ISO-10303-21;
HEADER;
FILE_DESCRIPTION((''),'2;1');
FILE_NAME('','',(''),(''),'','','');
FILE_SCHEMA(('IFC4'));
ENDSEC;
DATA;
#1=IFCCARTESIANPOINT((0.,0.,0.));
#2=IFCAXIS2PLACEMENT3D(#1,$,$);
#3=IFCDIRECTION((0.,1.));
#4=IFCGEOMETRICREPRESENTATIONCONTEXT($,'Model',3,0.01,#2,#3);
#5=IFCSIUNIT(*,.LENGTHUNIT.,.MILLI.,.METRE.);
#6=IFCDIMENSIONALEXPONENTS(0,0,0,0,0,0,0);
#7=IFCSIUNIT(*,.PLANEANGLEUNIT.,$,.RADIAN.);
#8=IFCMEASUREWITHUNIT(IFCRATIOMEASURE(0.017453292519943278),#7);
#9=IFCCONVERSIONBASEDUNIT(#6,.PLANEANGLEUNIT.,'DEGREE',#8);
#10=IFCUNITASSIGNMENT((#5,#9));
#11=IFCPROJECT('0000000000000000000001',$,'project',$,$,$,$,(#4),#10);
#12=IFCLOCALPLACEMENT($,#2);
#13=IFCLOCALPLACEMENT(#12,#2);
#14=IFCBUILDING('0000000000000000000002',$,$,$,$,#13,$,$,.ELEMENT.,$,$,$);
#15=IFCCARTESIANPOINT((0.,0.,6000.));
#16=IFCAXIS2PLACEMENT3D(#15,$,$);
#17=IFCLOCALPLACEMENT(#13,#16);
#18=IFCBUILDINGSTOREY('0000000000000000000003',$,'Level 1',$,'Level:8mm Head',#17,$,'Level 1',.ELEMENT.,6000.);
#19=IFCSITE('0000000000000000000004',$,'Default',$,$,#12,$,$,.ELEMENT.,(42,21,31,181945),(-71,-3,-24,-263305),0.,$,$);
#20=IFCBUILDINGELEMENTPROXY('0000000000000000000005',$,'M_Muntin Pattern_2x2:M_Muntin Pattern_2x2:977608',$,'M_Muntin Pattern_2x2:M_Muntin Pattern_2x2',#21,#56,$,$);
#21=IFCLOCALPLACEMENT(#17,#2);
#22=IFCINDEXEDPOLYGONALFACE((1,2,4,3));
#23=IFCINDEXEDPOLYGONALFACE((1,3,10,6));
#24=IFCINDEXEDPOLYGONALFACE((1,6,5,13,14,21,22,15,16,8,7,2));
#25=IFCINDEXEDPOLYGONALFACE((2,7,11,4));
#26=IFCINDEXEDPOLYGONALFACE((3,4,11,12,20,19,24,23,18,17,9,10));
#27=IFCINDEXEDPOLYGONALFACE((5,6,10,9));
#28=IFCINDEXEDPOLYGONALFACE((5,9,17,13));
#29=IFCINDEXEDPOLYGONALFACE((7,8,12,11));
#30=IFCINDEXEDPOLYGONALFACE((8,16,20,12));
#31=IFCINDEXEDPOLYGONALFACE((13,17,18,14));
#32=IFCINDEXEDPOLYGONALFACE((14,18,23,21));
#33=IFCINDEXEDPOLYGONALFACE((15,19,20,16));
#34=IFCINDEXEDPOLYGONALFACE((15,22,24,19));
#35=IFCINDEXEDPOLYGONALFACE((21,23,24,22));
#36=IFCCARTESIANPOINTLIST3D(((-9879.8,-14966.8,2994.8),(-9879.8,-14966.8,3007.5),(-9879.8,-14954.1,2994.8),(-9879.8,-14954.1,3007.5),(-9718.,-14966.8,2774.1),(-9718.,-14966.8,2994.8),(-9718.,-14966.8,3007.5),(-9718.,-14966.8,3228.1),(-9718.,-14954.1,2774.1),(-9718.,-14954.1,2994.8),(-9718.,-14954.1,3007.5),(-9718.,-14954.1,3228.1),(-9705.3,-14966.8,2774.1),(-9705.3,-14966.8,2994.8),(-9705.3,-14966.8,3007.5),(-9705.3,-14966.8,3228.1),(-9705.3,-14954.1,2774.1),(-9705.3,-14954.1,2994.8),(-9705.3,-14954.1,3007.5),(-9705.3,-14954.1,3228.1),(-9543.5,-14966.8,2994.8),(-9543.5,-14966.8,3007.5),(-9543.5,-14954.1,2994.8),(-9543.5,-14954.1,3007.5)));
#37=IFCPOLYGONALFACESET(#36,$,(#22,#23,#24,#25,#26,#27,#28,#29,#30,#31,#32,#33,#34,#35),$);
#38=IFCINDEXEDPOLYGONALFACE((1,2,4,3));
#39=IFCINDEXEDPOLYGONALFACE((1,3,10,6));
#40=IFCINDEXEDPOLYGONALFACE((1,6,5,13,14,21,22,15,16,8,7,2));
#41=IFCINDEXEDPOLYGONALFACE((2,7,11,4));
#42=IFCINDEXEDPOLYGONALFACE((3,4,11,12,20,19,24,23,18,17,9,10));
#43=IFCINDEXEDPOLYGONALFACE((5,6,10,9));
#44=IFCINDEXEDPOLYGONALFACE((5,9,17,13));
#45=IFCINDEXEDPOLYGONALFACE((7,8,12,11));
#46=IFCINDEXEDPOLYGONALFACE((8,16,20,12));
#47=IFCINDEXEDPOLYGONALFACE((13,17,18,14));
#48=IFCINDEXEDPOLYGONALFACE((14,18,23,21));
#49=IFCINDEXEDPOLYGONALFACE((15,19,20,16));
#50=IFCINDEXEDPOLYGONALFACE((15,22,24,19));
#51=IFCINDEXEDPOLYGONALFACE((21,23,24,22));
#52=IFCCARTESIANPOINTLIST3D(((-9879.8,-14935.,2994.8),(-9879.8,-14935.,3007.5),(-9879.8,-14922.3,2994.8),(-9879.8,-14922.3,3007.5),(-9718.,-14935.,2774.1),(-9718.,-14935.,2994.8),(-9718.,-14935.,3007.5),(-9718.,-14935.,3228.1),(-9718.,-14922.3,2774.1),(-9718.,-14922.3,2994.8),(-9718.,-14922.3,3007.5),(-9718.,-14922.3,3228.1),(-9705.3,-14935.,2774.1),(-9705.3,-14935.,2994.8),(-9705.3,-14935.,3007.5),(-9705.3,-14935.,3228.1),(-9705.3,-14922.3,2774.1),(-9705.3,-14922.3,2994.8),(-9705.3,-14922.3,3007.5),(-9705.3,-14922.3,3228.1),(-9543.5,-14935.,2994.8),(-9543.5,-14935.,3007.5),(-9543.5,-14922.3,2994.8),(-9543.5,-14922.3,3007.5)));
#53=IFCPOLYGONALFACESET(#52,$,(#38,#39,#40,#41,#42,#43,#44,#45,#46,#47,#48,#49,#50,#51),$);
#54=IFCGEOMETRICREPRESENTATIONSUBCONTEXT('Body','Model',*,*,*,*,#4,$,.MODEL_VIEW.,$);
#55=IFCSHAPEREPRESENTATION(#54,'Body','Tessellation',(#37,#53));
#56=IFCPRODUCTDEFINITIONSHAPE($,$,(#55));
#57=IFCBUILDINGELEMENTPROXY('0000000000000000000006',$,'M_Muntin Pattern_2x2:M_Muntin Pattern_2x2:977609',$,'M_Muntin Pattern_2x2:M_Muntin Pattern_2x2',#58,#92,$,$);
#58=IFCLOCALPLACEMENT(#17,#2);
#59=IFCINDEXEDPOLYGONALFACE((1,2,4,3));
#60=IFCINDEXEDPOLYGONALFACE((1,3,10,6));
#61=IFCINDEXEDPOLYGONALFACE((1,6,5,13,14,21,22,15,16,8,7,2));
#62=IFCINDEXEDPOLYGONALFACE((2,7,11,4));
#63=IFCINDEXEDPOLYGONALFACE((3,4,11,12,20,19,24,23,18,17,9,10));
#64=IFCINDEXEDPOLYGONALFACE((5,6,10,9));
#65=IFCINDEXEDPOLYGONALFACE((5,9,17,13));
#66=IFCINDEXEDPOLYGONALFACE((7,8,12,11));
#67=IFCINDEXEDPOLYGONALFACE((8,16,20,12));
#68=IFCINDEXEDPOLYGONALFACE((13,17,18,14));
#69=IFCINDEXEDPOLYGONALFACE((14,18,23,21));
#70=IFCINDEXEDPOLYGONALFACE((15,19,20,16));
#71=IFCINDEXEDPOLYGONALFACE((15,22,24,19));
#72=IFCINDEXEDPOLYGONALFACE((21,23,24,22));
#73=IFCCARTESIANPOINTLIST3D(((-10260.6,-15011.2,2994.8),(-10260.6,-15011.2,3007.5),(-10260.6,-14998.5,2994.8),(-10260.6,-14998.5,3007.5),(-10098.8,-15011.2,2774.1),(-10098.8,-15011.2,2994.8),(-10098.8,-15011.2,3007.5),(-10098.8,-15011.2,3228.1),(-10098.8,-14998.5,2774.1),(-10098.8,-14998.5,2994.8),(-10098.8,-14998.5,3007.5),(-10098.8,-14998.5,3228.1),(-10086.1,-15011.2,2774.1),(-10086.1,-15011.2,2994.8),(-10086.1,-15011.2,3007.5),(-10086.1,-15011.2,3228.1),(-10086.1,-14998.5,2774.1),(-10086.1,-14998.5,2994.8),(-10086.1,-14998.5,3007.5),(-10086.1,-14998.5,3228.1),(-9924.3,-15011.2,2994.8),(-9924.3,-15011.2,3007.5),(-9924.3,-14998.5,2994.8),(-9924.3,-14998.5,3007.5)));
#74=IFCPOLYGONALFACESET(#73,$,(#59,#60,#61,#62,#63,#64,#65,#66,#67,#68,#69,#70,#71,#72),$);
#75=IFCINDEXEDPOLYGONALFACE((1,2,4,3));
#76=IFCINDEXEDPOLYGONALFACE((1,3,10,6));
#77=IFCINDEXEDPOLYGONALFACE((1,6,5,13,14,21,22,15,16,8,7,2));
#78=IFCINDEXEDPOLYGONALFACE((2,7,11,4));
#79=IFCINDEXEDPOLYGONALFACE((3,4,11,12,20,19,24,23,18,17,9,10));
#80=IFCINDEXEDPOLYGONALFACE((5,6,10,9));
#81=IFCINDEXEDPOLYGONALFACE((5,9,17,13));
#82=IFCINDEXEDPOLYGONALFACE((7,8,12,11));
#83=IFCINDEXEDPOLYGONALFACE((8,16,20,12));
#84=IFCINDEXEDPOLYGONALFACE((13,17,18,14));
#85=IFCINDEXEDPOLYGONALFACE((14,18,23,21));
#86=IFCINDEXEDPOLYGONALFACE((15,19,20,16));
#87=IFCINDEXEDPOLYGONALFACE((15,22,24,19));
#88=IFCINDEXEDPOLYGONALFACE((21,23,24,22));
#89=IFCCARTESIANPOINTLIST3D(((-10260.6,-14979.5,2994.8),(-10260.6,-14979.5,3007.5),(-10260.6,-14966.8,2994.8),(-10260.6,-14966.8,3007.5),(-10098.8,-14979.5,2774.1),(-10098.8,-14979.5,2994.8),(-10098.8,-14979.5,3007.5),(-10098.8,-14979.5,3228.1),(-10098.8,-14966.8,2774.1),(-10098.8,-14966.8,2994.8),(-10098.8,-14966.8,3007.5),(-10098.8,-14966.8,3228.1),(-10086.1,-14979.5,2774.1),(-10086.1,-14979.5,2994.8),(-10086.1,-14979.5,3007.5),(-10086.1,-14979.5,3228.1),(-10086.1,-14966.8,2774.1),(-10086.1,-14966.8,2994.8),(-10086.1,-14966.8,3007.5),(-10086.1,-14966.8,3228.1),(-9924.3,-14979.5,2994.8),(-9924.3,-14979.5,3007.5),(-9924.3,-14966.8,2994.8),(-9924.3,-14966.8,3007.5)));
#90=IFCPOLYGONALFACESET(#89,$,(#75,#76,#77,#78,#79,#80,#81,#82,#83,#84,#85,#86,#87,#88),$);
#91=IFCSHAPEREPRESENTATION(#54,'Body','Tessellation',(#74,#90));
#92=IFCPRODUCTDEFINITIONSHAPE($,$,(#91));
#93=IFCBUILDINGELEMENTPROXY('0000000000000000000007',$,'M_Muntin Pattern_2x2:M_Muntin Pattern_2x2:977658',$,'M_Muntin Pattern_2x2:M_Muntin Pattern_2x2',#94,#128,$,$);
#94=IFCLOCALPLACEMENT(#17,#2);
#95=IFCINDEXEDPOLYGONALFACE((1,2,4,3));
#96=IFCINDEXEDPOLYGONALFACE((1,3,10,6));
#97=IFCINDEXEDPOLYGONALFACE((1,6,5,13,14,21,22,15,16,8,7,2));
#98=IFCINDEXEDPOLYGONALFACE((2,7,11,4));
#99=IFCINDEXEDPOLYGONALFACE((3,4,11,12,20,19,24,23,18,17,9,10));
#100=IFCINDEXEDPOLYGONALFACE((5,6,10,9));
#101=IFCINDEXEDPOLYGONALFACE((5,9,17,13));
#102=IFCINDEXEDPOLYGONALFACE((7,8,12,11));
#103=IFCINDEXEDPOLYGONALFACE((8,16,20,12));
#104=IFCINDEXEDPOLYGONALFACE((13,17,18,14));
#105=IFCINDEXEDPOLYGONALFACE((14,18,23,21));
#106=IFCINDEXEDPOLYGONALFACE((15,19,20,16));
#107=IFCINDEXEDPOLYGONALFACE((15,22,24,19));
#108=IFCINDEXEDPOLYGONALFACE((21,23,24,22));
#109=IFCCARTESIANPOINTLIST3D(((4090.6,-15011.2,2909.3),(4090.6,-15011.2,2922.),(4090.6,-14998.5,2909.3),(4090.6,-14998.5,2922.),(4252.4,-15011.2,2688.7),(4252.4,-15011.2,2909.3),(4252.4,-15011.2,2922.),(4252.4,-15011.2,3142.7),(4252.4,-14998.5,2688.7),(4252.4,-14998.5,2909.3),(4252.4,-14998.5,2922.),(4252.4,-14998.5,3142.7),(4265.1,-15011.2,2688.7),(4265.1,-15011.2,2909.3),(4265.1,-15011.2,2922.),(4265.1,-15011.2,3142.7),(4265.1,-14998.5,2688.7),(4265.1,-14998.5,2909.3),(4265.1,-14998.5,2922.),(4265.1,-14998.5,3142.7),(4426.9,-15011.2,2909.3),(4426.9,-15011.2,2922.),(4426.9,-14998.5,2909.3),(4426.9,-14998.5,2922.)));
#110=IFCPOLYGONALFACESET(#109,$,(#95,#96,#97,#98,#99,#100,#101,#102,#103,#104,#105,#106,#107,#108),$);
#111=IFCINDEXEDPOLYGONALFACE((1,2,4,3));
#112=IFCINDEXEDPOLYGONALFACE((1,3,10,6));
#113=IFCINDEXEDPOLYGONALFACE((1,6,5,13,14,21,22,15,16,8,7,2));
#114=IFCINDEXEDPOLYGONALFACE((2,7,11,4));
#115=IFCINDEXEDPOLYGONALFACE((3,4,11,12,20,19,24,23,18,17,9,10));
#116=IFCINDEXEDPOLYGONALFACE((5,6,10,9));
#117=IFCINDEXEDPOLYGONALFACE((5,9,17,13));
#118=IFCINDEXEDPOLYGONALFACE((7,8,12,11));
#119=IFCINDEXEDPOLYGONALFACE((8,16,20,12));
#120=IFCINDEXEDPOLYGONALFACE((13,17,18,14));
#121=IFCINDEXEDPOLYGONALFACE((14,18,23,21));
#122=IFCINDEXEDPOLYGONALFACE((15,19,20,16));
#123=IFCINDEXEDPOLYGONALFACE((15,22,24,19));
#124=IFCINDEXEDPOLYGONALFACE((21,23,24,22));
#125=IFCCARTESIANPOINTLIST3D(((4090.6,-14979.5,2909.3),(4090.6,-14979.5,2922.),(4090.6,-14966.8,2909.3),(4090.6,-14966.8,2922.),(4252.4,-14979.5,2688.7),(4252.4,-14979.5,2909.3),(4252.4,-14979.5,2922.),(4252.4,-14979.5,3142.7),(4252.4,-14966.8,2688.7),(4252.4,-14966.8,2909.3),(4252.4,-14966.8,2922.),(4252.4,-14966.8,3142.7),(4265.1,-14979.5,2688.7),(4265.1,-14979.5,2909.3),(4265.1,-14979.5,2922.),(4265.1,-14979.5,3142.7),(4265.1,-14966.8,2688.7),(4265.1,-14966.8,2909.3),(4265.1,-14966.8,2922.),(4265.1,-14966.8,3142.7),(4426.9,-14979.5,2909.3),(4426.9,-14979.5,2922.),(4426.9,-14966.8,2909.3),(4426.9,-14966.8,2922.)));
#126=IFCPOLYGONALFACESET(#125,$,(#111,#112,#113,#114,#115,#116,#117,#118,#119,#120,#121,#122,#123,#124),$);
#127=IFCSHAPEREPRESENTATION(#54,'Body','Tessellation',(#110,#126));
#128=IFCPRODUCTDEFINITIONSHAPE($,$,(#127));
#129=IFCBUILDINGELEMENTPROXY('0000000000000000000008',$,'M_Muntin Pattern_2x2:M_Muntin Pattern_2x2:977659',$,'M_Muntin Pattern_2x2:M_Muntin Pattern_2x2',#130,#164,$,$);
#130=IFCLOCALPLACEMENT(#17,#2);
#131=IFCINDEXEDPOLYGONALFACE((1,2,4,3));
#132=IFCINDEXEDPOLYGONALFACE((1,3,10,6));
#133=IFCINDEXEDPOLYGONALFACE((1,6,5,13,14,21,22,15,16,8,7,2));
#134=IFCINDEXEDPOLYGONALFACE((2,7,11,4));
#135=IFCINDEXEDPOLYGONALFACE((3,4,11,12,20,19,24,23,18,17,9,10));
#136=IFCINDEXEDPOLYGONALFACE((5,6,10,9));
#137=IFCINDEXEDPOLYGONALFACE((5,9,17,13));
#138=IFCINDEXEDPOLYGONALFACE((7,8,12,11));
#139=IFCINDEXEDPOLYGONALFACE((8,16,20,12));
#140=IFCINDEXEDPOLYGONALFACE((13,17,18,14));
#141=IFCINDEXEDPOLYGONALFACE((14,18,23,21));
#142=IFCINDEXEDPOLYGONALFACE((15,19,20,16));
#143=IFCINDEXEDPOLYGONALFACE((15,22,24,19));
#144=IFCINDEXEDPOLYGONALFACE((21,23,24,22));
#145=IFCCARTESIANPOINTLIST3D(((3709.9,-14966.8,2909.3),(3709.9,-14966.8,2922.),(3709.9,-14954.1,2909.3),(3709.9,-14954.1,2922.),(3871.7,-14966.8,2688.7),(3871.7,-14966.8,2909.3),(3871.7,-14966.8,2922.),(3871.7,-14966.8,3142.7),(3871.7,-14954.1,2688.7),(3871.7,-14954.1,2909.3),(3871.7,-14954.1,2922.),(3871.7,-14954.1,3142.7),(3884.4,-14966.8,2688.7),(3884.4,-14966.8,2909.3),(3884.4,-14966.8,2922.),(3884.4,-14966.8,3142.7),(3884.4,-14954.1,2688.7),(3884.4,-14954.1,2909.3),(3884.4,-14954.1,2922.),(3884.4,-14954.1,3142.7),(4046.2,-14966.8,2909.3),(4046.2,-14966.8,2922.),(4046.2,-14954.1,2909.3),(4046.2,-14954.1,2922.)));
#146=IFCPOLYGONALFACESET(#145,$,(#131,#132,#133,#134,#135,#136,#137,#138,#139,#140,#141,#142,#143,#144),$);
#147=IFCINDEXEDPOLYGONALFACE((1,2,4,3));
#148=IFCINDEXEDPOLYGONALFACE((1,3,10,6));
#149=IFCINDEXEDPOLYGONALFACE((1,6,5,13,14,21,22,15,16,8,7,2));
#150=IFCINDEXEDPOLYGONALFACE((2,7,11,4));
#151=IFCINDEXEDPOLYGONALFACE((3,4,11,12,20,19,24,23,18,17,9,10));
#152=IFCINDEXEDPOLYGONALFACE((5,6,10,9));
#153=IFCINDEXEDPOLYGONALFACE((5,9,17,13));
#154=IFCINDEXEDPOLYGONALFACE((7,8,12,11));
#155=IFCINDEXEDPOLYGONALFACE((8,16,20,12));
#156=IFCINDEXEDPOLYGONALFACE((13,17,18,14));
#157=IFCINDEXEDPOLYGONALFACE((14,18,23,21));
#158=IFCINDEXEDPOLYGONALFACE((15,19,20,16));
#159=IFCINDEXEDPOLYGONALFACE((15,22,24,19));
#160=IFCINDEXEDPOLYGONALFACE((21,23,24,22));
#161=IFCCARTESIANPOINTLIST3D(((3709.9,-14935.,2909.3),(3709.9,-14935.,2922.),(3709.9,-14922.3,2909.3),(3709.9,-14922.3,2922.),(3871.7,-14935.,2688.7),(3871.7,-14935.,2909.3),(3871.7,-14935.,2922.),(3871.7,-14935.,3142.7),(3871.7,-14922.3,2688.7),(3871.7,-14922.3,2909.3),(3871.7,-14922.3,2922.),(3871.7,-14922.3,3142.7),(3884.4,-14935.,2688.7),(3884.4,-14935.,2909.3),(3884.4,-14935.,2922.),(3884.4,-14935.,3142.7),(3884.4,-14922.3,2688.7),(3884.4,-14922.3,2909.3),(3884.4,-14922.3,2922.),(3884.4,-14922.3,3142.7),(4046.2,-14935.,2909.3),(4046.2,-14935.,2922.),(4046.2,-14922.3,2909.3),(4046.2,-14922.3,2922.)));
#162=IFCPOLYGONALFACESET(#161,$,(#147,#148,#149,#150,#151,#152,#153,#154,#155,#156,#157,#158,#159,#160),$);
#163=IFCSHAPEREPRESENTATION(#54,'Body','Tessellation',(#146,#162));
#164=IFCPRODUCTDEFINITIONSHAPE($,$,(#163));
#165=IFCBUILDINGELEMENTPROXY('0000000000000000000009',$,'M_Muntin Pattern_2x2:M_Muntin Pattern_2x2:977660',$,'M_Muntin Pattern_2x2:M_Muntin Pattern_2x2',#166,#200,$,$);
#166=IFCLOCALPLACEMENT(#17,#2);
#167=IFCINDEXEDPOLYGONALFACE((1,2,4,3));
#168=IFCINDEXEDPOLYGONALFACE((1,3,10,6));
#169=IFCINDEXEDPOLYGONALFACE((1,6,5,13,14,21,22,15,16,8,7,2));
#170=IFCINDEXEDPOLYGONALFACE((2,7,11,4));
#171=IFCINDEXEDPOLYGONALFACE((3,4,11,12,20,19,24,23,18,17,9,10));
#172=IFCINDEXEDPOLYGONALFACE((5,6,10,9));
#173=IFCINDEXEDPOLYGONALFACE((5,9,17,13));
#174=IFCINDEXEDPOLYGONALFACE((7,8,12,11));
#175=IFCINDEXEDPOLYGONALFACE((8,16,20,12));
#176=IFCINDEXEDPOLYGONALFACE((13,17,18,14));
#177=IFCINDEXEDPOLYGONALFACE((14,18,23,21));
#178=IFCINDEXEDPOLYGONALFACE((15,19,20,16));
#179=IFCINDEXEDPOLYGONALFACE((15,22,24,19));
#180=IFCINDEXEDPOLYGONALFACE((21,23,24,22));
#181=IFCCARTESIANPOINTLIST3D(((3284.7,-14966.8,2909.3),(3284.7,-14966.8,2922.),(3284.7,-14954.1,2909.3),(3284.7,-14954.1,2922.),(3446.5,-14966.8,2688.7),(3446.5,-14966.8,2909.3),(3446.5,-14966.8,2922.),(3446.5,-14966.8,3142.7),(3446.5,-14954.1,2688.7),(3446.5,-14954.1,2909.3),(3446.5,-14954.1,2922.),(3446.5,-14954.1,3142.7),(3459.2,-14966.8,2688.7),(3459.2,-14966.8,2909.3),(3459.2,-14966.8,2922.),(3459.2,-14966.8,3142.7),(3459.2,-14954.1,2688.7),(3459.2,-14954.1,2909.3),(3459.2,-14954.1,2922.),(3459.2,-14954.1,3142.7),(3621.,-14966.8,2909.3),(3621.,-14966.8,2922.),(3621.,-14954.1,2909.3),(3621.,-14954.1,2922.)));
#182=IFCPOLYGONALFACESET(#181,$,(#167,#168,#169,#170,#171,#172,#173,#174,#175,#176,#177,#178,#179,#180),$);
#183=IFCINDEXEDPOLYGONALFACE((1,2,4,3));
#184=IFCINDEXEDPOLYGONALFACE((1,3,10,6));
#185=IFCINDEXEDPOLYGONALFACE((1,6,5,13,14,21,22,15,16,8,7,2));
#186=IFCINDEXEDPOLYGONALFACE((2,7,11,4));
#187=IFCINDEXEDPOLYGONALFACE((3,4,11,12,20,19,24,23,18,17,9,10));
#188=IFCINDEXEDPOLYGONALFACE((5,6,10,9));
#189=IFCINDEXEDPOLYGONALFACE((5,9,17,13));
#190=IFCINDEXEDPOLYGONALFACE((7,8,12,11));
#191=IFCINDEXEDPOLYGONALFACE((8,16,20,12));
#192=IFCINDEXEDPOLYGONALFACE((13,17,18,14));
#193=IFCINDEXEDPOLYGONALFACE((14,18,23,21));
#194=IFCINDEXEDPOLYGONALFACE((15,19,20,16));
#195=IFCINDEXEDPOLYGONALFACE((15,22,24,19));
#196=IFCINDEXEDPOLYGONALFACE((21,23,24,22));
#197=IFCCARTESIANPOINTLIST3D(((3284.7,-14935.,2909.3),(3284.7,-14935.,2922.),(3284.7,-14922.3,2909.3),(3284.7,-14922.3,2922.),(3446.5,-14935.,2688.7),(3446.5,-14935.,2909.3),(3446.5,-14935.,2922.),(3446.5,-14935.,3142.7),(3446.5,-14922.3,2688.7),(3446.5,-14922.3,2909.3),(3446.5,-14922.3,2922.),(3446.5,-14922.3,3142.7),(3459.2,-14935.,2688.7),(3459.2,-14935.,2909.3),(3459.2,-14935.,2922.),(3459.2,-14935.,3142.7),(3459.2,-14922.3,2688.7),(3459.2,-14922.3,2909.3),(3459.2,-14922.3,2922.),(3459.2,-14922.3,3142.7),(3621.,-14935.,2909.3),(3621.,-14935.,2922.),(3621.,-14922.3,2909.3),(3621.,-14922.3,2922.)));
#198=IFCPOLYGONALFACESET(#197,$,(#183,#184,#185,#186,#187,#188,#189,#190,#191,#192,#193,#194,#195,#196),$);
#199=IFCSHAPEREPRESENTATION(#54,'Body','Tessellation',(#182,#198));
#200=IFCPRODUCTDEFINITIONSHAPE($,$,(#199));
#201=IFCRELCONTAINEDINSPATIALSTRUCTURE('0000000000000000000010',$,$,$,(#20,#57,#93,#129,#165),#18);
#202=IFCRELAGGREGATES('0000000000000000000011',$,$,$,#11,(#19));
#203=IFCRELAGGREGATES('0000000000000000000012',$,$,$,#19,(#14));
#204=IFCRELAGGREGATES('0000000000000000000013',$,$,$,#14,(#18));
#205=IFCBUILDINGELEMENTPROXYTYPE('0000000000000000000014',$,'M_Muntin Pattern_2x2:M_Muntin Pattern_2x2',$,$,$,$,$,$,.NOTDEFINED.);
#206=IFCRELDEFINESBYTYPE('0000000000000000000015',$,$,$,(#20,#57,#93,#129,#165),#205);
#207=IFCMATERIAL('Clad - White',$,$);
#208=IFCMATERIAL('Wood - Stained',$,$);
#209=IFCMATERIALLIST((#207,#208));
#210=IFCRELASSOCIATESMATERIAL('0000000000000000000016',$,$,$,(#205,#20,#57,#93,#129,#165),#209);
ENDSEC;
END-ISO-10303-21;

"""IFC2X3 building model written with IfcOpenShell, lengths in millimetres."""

from ifc_helpers import new_model, entity, si_unit, converted_unit, direction, frame, origin, place, context, subcontext, project, spatial, polyline, outline, extrude, source, transform, mapped, material, material_list, type_object, type_shapes, element, save


model = new_model("IFC2X3")

# Units and contexts
model_context = context("Model", 3, precision=0.01, world=origin(), true_north=direction((0.0, 1.0)))
body_context = subcontext(model_context, "Body", "Model", "MODEL_VIEW")
ifc_project = project(units=[si_unit("LENGTHUNIT", "METRE", prefix="MILLI"), converted_unit("PLANEANGLEUNIT", "DEGREE", entity("IfcRatioMeasure", 0.017453292519943278), si_unit("PLANEANGLEUNIT", "RADIAN"), dimensions=[0, 0, 0, 0, 0, 0, 0])], contexts=[model_context])

# Site, building, storey
site_placement = place(None, origin())
site = spatial("IfcSite", under=ifc_project, at=site_placement, Name="Default", CompositionType="ELEMENT", RefLatitude=(42, 21, 31, 181945), RefLongitude=(-71, -3, -24, -263305), RefElevation=0.0)
building_placement = place(site_placement, origin())
building = spatial("IfcBuilding", under=site, at=building_placement, CompositionType="ELEMENT")
storey_placement = place(building_placement, frame((0.0, 0.0, 6000.0)))
storey = spatial("IfcBuildingStorey", under=building, at=storey_placement, Name="Level 1", ObjectType="Level:8mm Head", LongName="Level 1", CompositionType="ELEMENT", Elevation=6000.0)

# Building element proxies
ifc_material_1 = material(Name="Clad - White")
ifc_material_2 = material(Name="Wood - Stained")
ifc_material_list_1 = material_list([ifc_material_1, ifc_material_2])
building_element_proxy_type_1 = type_object("IfcBuildingElementProxyType", Name="M_Muntin Pattern_2x2:M_Muntin Pattern_2x2", PredefinedType="NOTDEFINED", material=ifc_material_list_1)
shared_shape_1 = source(origin(), body_context, "Body", "SweptSolid", [
    extrude(outline(polyline([(6.4, -6.4), (227.0, -6.4), (227.0, 6.3), (6.4, 6.3), (6.4, 168.2), (-6.3, 168.2), (-6.3, 6.3), (-227.0, 6.3), (-227.0, -6.4), (-6.3, -6.4), (-6.3, -168.1), (6.4, -168.1), (6.4, -6.4)])), frame((0.0, 9.5, 227.0), z_axis=(0.0, 1.0, 0.0), x_axis=(0.0, 0.0, 1.0)), (0.0, 0.0, 1.0), 12.7),
    extrude(outline(polyline([(6.4, -6.4), (227.0, -6.4), (227.0, 6.3), (6.4, 6.3), (6.4, 168.2), (-6.3, 168.2), (-6.3, 6.3), (-227.0, 6.3), (-227.0, -6.4), (-6.3, -6.4), (-6.3, -168.1), (6.4, -168.1), (6.4, -6.4)])), frame((0.0, -22.2, 227.0), z_axis=(0.0, 1.0, 0.0), x_axis=(0.0, 0.0, 1.0)), (0.0, 0.0, 1.0), 12.7),
])
type_shapes(building_element_proxy_type_1, [shared_shape_1])
for number, where, z_axis, x_axis, name in (
    (1, (-9711.7, -14944.6, 2774.1), (0.0, 0.0, 1.0), (-1.0, 0.0, 0.0), "M_Muntin Pattern_2x2:M_Muntin Pattern_2x2:977608"),
    (2, (-10092.4, -14989.0, 2774.1), (0.0, 0.0, 1.0), (-1.0, 0.0, 0.0), "M_Muntin Pattern_2x2:M_Muntin Pattern_2x2:977609"),
    (3, (4258.8, -14989.0, 2688.7), (0.0, 0.0, 1.0), (-1.0, 0.0, 0.0), "M_Muntin Pattern_2x2:M_Muntin Pattern_2x2:977658"),
    (4, (3878.0, -14944.6, 2688.7), (0.0, 0.0, 1.0), (-1.0, 0.0, 0.0), "M_Muntin Pattern_2x2:M_Muntin Pattern_2x2:977659"),
    (5, (3452.8, -14944.6, 2688.7), (0.0, 0.0, 1.0), (-1.0, 0.0, 0.0), "M_Muntin Pattern_2x2:M_Muntin Pattern_2x2:977660"),
):
    element("IfcBuildingElementProxy", number, at=place(storey_placement, frame(where, z_axis=z_axis, x_axis=x_axis)), inside=storey, type_object=building_element_proxy_type_1, material=ifc_material_list_1, Name=name, ObjectType="M_Muntin Pattern_2x2:M_Muntin Pattern_2x2", context=body_context, shape_type="MappedRepresentation", body=[
        mapped(shared_shape_1, transform((0.0, 0.0, 0.0), scale=1.0)),
    ])

save(model, "model.ifc")
